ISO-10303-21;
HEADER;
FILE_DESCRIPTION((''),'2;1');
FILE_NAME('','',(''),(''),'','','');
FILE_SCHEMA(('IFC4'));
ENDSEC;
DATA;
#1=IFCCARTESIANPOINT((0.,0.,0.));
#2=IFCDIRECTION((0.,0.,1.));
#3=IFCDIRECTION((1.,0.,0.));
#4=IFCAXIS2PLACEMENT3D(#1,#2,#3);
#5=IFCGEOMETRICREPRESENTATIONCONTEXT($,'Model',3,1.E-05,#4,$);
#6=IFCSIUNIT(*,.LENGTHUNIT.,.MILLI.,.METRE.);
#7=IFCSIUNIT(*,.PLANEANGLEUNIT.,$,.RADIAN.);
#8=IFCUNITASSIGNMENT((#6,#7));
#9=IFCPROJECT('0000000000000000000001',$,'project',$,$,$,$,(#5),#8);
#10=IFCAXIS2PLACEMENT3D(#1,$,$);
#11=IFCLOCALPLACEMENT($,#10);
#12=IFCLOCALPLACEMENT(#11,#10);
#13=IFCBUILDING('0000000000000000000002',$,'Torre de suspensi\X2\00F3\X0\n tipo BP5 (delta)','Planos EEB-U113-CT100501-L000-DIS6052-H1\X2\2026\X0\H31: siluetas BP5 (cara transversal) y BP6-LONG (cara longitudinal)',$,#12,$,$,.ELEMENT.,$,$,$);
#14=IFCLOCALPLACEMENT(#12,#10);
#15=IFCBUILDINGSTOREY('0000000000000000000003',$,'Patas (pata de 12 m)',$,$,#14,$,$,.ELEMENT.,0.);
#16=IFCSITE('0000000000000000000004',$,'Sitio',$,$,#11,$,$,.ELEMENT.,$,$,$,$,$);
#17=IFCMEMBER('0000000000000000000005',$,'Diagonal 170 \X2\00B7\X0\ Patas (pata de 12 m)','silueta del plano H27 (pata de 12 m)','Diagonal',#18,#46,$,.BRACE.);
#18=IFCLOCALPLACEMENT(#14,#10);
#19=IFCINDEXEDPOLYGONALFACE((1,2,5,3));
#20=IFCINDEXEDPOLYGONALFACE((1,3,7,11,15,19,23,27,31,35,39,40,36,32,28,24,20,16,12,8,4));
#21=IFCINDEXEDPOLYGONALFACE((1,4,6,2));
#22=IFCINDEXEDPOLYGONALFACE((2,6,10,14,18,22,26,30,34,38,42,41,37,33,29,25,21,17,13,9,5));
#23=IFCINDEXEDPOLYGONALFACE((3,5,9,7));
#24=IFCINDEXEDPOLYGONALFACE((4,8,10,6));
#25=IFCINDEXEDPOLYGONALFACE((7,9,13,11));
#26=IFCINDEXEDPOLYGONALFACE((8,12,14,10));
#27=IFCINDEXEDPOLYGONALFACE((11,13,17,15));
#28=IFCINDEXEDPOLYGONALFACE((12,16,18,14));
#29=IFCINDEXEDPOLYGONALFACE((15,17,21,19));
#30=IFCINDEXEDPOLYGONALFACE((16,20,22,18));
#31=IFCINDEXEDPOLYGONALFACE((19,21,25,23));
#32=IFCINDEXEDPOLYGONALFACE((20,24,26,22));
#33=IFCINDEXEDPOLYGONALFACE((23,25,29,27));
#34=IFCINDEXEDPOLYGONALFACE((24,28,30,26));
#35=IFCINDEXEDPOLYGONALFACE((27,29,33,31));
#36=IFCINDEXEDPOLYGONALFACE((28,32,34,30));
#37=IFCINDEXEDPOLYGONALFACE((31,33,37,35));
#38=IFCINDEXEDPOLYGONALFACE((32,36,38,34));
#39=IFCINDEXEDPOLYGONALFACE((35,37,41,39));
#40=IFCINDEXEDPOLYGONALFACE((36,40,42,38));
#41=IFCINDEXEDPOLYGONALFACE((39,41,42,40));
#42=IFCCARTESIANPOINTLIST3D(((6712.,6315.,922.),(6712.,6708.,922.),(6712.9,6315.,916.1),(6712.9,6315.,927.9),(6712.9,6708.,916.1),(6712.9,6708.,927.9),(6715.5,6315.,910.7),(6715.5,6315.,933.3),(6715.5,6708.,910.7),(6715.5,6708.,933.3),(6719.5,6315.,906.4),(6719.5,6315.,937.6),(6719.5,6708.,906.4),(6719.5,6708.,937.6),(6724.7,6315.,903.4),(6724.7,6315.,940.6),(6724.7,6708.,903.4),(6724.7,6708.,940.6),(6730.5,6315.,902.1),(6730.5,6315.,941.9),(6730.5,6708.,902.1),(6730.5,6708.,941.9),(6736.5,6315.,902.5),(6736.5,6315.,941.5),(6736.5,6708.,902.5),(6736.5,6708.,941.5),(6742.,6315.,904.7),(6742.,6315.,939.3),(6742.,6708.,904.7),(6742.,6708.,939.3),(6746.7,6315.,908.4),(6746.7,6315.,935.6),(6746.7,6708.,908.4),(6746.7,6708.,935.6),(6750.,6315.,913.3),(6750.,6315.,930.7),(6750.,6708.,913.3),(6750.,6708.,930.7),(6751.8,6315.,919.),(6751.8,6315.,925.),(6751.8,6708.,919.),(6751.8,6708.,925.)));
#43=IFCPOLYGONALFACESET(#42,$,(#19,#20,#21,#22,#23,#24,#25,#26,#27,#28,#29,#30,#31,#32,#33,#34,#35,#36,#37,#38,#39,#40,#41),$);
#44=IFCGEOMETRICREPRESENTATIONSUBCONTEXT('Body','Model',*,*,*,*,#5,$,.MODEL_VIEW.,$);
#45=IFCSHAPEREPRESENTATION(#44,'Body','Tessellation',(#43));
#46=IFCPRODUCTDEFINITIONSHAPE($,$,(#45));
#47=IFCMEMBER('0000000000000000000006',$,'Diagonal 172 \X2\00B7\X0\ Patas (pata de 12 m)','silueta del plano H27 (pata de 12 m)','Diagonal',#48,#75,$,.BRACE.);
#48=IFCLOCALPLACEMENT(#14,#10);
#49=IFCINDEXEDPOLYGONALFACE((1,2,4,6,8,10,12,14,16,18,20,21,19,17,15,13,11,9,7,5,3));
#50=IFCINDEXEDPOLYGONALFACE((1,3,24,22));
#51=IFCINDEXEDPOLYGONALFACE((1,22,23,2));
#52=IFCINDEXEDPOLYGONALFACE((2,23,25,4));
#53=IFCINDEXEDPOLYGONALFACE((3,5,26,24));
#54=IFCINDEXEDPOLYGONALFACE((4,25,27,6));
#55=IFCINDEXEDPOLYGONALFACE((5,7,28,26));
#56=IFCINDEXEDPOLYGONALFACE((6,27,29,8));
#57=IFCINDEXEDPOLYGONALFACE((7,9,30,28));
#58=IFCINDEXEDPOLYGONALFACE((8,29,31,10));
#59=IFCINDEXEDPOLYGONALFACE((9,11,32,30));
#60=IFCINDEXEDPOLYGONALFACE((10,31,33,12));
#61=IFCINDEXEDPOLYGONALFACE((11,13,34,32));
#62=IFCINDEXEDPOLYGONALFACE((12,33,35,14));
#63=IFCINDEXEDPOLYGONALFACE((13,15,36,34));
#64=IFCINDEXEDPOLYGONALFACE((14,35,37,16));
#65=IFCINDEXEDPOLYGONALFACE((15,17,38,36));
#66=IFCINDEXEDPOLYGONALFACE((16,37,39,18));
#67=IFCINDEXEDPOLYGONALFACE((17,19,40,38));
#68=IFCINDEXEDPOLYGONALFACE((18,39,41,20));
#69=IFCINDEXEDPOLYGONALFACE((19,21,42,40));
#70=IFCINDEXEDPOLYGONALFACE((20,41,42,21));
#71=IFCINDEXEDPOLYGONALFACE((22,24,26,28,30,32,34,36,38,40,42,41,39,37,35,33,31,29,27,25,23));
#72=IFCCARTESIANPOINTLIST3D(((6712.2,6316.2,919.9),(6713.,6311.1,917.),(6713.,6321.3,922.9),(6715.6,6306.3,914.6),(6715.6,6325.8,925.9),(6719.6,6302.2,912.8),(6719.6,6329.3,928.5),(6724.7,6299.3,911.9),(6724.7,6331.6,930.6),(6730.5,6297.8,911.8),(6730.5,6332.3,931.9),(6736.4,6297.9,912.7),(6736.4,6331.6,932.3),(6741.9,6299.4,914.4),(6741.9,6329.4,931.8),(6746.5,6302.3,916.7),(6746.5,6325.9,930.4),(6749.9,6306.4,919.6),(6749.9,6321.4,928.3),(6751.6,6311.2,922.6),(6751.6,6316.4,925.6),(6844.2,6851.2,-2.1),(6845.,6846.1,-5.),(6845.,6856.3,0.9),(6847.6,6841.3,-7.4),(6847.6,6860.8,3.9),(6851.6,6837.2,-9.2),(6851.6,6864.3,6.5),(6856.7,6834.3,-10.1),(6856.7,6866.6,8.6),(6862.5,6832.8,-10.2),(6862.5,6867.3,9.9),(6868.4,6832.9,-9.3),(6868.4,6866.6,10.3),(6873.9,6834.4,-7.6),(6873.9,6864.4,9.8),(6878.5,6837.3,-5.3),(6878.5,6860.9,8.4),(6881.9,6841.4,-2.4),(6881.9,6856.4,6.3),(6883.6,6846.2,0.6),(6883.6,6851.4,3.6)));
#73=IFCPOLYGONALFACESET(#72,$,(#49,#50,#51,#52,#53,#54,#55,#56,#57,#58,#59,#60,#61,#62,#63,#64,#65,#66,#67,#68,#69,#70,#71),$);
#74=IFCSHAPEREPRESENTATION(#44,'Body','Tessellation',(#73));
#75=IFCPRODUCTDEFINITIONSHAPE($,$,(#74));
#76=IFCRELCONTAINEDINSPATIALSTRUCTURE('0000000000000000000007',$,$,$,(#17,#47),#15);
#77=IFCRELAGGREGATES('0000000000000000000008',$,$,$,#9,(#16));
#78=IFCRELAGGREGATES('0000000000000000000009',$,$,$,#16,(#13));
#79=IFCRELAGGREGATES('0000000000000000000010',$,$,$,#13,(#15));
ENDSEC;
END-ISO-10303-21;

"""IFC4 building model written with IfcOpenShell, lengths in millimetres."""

from ifc_helpers import new_model, si_unit, frame, origin, origin_with_axes, place, context, subcontext, project, spatial, circle, extrude, element, save


model = new_model("IFC4")

# Units and contexts
model_context = context("Model", 3, precision=1e-05, world=origin_with_axes())
body_context = subcontext(model_context, "Body", "Model", "MODEL_VIEW")
ifc_project = project(units=[si_unit("LENGTHUNIT", "METRE", prefix="MILLI"), si_unit("PLANEANGLEUNIT", "RADIAN")], contexts=[model_context])

# Site, building, storey
site_placement = place(None, origin())
site = spatial("IfcSite", under=ifc_project, at=site_placement, Name="Sitio", CompositionType="ELEMENT")
building_placement = place(site_placement, origin())
building = spatial("IfcBuilding", under=site, at=building_placement, Name="Torre de suspensión tipo BP5 (delta)", Description="Planos EEB-U113-CT100501-L000-DIS6052-H1…H31: siluetas BP5 (cara transversal) y BP6-LONG (cara longitudinal)", CompositionType="ELEMENT")
storey_placement = place(building_placement, origin())
storey = spatial("IfcBuildingStorey", under=building, at=storey_placement, Name="Patas (pata de 12 m)", CompositionType="ELEMENT", Elevation=0.0)

# Members
member_1_placement = place(storey_placement, frame((6732.0, 6708.0, 922.0), z_axis=(0.0, -1.0, 0.0), x_axis=(-1.0, 0.0, 0.0)))
element("IfcMember", 1, at=member_1_placement, inside=storey, Name="Diagonal 170 · Patas (pata de 12 m)", Description="silueta del plano H27 (pata de 12 m)", ObjectType="Diagonal", PredefinedType="BRACE", context=body_context, shape_type="SweptSolid", body=[
    extrude(circle(Radius=20.0), None, (0.0, 0.0, 1.0), 393.0),
])
member_2_placement = place(storey_placement, frame((6864.0, 6850.0, 0.0), z_axis=(-0.122891, -0.498082, 0.858377), x_axis=(-0.99242, 0.061678, -0.106293)))
element("IfcMember", 2, at=member_2_placement, inside=storey, Name="Diagonal 172 · Patas (pata de 12 m)", Description="silueta del plano H27 (pata de 12 m)", ObjectType="Diagonal", PredefinedType="BRACE", context=body_context, shape_type="SweptSolid", body=[
    extrude(circle(Radius=20.0), None, (0.0, 0.0, 1.0), 1074.1),
])

save(model, "model.ifc")
